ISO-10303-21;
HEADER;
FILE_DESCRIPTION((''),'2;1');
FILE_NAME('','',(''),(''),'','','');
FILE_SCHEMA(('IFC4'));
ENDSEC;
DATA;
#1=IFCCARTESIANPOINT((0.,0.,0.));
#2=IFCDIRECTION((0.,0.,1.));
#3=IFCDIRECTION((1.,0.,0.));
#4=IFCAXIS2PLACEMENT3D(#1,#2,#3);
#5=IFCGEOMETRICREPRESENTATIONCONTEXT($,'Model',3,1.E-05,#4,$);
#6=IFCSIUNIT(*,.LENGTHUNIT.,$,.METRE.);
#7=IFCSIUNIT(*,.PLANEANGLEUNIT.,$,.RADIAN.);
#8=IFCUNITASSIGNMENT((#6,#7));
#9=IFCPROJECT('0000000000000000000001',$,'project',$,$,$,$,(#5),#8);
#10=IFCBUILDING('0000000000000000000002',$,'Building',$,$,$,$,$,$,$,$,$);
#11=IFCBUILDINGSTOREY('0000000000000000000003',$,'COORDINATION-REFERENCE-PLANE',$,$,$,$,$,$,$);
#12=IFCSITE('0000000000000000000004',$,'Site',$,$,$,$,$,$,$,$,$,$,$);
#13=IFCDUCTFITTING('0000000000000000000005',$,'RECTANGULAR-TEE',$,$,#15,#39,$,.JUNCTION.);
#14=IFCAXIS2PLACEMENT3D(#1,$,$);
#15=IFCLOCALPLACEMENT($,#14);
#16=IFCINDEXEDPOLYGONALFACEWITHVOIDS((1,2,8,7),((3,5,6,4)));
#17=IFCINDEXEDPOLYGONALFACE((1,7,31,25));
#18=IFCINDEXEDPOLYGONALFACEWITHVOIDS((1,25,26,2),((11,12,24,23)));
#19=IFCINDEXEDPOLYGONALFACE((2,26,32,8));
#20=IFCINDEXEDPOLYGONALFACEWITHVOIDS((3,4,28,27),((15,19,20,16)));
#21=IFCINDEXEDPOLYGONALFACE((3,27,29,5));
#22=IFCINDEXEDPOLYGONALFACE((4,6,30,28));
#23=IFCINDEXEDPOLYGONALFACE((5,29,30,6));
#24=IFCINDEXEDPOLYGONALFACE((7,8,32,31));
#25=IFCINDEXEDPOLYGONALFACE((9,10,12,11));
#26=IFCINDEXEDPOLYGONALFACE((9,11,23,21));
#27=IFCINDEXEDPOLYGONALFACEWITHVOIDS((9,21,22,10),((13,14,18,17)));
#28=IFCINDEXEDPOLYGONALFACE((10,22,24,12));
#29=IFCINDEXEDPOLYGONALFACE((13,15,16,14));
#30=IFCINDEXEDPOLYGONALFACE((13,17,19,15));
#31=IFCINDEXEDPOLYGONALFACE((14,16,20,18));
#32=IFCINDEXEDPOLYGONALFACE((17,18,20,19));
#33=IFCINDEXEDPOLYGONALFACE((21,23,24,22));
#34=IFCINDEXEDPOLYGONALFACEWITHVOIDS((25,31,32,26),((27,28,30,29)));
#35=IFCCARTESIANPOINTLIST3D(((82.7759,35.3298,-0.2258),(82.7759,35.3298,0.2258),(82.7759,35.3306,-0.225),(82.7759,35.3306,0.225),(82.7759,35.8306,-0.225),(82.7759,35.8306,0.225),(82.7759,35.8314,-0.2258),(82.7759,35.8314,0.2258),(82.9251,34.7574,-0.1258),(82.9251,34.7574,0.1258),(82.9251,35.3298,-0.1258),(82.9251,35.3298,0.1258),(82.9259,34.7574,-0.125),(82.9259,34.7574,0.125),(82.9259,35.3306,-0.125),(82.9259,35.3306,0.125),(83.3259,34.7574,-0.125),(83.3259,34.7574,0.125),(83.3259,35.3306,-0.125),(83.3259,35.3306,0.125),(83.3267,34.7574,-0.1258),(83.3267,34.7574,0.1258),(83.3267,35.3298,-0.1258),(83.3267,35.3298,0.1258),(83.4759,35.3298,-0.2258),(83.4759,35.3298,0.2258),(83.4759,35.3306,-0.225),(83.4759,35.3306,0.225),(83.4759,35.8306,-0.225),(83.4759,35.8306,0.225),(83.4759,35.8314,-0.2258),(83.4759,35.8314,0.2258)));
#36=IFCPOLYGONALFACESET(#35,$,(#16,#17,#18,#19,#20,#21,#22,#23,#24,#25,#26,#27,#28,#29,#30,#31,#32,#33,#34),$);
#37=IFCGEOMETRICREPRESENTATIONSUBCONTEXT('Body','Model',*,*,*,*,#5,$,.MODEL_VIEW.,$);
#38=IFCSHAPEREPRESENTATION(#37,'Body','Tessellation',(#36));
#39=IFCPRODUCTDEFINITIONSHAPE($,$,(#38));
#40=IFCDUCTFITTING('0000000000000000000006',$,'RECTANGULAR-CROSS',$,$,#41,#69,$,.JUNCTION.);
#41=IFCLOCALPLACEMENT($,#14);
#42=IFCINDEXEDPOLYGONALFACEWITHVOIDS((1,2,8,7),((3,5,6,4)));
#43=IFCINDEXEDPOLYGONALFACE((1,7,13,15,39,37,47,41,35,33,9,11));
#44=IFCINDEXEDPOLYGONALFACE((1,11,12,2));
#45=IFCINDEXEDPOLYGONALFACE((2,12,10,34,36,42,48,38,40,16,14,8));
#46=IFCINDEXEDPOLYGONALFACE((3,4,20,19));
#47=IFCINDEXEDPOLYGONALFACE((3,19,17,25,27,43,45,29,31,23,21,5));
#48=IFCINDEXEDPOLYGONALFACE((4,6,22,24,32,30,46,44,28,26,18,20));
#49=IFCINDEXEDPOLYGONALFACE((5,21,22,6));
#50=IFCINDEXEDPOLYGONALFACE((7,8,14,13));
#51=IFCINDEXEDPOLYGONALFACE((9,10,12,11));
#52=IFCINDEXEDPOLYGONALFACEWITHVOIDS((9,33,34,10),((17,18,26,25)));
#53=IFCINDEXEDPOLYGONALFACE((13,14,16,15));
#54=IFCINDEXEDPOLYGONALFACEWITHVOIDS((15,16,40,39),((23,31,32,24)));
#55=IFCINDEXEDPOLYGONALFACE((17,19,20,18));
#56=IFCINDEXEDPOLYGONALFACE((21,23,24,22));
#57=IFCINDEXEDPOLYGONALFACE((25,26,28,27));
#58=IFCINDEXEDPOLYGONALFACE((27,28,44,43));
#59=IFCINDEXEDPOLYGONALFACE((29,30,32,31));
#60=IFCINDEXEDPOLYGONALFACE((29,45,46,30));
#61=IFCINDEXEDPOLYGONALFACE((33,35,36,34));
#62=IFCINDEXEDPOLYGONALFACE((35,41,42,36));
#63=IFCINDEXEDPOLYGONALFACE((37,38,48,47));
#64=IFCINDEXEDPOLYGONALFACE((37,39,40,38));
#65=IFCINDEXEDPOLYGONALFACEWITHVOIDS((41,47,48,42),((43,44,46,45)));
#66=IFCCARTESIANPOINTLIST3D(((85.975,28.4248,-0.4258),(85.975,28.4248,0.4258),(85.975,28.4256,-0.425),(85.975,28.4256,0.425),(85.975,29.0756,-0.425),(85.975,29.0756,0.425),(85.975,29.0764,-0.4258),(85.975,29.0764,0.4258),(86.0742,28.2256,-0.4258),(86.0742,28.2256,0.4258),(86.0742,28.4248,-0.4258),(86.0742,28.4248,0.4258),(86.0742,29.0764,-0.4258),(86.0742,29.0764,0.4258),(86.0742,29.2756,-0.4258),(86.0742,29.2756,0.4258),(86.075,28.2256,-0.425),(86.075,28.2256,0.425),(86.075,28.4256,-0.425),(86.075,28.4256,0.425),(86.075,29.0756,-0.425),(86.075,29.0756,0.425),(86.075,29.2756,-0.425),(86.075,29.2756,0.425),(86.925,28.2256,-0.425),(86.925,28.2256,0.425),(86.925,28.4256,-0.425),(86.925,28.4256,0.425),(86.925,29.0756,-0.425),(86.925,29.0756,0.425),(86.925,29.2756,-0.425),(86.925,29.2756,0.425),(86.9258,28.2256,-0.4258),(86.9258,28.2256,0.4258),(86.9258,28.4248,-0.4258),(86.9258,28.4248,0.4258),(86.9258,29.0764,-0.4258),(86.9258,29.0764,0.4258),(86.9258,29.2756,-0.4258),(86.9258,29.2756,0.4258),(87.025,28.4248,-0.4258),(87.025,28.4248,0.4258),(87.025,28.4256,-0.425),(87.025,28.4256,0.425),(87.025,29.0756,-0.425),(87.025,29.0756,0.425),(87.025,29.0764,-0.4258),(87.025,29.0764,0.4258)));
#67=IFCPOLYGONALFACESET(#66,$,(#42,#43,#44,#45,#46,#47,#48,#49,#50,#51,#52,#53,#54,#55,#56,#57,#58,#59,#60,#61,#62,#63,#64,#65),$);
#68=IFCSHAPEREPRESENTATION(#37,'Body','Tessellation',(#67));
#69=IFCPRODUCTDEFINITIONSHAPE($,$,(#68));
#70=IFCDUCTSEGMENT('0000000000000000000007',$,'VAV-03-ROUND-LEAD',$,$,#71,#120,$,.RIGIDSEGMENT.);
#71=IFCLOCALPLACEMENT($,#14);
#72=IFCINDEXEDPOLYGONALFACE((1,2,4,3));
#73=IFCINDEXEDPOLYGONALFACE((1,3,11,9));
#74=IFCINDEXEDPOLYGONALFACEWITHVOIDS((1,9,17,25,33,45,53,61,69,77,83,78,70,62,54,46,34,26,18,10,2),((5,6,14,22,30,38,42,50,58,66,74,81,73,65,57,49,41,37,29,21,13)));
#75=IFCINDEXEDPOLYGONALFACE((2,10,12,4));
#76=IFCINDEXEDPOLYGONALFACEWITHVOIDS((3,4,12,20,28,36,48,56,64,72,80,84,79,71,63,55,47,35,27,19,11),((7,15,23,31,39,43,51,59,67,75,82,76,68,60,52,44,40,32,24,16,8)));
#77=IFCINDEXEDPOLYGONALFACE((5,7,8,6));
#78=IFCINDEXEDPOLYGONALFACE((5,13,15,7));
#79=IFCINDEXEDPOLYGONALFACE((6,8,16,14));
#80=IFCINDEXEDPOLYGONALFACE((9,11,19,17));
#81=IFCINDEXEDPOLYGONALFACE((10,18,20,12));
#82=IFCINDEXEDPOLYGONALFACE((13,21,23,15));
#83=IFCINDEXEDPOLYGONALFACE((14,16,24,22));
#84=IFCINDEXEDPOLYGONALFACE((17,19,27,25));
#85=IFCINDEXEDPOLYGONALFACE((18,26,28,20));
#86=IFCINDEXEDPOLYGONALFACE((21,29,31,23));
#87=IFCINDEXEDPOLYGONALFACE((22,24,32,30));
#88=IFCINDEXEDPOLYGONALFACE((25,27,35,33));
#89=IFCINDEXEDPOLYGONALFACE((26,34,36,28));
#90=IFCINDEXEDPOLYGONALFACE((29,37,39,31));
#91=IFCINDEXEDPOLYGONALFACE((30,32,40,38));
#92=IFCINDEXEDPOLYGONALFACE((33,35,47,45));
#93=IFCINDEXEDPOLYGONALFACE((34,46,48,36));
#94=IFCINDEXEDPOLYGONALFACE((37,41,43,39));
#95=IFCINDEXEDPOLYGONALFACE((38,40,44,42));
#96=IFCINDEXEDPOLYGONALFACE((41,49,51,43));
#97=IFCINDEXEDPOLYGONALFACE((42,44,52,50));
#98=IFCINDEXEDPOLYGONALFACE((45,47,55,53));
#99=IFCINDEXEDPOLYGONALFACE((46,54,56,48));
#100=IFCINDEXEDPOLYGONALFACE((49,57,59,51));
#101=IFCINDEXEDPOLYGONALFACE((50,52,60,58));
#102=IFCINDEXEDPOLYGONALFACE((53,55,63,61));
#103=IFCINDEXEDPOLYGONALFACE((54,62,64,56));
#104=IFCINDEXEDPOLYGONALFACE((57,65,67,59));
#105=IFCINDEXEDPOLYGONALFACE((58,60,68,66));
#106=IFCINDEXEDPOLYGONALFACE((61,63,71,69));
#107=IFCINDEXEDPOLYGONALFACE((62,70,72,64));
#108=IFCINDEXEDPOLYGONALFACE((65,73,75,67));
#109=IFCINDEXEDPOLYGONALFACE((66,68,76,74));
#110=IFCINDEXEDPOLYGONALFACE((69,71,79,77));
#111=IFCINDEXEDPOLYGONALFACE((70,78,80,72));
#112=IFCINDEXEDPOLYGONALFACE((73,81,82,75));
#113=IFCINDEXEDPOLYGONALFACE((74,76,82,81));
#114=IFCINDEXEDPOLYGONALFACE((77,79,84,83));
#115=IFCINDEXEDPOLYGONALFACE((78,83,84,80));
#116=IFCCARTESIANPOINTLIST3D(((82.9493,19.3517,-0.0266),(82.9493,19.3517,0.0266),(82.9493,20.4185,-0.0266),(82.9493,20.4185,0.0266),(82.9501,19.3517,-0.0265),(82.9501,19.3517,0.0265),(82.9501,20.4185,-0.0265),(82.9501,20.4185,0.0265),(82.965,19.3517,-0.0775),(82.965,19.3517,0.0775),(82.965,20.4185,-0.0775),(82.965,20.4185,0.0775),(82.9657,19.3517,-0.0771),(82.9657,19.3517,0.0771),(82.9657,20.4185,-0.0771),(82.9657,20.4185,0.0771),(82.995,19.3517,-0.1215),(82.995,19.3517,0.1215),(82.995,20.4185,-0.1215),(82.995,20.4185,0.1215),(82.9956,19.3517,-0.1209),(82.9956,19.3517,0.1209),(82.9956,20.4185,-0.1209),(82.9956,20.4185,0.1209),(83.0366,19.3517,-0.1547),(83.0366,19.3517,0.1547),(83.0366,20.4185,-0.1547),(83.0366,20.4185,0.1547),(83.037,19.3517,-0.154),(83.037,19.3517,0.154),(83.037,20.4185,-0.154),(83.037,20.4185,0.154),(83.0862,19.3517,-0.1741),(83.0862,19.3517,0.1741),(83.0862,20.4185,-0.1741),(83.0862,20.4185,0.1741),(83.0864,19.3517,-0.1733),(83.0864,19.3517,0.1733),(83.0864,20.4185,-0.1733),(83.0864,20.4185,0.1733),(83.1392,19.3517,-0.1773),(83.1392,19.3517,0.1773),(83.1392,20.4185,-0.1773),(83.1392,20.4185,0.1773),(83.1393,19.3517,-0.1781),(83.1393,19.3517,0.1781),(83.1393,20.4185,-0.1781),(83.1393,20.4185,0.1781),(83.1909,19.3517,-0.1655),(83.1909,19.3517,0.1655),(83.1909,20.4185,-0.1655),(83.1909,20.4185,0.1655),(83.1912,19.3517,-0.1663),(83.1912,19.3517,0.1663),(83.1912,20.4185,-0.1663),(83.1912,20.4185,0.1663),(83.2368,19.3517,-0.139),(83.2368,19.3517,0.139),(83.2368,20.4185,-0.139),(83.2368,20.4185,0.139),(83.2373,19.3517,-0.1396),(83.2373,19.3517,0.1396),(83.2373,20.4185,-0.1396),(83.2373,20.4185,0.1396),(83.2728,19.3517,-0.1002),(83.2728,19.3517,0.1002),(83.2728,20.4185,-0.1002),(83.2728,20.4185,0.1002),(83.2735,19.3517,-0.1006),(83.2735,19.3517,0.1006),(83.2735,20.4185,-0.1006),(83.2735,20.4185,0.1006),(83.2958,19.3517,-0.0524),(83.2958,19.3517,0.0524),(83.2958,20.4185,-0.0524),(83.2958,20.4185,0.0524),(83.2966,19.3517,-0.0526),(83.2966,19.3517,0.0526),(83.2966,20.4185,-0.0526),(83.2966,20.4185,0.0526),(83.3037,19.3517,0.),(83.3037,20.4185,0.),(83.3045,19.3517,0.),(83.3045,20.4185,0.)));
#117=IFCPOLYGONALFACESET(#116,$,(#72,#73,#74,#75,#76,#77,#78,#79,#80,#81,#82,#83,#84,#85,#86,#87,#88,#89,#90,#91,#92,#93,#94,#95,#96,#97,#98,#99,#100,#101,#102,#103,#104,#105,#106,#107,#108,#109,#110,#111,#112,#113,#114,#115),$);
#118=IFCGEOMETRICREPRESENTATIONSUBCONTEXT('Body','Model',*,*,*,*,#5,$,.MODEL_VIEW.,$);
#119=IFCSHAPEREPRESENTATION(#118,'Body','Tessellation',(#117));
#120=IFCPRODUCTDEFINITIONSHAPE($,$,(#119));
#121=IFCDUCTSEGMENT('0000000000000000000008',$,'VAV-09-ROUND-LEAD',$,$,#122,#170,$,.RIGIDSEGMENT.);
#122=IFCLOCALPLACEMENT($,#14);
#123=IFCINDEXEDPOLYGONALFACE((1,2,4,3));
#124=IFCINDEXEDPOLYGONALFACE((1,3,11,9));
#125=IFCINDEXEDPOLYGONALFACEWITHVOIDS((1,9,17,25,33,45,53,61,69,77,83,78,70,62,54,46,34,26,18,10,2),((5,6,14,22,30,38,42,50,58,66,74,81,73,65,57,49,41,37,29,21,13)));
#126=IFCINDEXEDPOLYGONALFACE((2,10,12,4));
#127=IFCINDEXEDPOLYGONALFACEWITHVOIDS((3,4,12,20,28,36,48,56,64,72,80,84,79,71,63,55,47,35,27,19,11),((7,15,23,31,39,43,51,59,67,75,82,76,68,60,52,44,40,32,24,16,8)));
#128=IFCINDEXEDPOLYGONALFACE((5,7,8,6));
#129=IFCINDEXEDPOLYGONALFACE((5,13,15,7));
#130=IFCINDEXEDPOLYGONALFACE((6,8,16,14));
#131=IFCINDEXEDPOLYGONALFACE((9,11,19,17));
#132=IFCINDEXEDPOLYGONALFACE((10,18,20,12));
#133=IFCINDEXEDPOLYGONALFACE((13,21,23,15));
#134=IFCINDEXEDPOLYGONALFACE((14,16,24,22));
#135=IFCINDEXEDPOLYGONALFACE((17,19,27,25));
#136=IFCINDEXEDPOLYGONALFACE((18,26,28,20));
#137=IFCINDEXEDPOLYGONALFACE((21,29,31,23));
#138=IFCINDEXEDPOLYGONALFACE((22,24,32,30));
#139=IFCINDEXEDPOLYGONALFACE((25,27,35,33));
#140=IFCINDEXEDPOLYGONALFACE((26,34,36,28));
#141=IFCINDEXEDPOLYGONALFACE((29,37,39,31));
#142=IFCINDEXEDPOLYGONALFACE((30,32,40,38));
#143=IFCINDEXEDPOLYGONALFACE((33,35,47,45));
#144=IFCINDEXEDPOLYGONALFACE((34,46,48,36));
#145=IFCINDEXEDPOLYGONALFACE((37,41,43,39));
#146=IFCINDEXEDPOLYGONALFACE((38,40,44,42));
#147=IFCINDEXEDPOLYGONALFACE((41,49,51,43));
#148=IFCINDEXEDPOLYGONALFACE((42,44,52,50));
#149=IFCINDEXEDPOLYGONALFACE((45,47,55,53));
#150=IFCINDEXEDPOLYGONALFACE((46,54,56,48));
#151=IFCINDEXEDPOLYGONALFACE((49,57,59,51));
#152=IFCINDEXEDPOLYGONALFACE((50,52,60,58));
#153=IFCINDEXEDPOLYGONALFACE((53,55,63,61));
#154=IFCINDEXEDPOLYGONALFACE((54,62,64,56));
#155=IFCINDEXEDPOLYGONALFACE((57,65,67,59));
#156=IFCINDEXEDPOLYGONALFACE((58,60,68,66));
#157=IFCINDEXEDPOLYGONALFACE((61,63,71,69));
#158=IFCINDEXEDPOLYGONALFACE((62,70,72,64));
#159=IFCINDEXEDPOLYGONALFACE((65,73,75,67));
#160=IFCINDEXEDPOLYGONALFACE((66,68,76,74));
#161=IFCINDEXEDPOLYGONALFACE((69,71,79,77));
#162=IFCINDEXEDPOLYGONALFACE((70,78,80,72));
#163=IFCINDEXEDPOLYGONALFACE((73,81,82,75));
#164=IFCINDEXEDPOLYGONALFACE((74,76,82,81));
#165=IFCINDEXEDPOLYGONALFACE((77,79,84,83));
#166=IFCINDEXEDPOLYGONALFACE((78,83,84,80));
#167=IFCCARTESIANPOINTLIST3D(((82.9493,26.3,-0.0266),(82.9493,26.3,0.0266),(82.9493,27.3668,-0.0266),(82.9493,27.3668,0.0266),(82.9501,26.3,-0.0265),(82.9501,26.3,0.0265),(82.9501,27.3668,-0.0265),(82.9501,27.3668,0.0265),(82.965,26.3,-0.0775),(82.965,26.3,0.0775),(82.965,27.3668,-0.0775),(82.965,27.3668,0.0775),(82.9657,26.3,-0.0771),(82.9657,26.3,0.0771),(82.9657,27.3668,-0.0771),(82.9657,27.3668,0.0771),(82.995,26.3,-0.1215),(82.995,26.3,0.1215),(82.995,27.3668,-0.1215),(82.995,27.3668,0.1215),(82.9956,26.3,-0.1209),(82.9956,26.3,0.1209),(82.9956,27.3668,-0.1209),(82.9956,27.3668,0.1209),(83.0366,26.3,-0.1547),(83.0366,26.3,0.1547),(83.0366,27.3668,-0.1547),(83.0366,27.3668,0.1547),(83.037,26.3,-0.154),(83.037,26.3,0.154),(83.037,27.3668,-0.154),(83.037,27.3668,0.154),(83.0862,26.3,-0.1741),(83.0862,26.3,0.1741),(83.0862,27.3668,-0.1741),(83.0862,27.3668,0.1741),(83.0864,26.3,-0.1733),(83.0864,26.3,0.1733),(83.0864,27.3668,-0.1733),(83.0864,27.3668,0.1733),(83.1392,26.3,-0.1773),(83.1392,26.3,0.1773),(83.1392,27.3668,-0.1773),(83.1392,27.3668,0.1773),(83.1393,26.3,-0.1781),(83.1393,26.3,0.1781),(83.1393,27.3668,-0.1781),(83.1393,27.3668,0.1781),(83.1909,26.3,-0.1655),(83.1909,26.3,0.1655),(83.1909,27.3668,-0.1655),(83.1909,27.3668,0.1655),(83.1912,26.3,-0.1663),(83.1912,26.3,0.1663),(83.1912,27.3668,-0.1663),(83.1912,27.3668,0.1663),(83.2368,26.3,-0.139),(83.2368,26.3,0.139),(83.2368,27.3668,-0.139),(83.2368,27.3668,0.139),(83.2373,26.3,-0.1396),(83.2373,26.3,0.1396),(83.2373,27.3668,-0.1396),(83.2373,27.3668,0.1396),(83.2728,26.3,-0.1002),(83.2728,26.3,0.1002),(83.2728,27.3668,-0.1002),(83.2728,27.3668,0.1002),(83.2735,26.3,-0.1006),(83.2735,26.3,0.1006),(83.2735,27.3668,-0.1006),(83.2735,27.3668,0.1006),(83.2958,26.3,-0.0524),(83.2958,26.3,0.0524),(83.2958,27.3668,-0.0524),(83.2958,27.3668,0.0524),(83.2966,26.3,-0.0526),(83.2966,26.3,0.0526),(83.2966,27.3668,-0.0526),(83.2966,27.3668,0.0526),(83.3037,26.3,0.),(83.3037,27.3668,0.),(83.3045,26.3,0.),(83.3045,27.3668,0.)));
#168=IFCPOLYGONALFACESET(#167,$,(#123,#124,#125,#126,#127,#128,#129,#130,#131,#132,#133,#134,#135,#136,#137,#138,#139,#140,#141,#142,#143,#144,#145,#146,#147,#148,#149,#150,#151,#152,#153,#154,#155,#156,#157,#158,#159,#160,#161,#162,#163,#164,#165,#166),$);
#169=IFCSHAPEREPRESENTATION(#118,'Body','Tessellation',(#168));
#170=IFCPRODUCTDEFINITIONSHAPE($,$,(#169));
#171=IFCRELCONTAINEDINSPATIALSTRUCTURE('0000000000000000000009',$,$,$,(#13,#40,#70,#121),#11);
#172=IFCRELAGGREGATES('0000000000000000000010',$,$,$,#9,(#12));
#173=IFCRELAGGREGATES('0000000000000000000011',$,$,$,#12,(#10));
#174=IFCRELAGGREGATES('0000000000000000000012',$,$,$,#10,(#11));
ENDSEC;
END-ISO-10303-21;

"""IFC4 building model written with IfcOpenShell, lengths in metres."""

from ifc_helpers import new_model, si_unit, frame, origin, origin_with_axes, place, context, subcontext, project, spatial, rectangle, hollow_circle, extrude, boolean, element, save


model = new_model("IFC4")

# Units and contexts
model_context = context("Model", 3, precision=1e-05, world=origin_with_axes())
body_context_1 = subcontext(model_context, "Body", "Model", "MODEL_VIEW")
body_context_2 = subcontext(model_context, "Body", "Model", "MODEL_VIEW")
ifc_project = project(units=[si_unit("LENGTHUNIT", "METRE"), si_unit("PLANEANGLEUNIT", "RADIAN")], contexts=[model_context])

# Site, building, storey
site = spatial("IfcSite", under=ifc_project, Name="Site")
building = spatial("IfcBuilding", under=site, Name="Building")
storey = spatial("IfcBuildingStorey", under=building, Name="COORDINATION-REFERENCE-PLANE")

# Duct fittings
duct_fitting_1_placement = place(None, frame((83.1259, 35.5806, 0.0), z_axis=(-1.0, 0.0, 0.0), x_axis=(0.0, -1.0, 0.0)))
solid_1 = boolean("UNION", extrude(rectangle(XDim=0.5, YDim=0.45), frame((0.0, 0.0, -0.35), z_axis=(0.0, 0.0, 1.0), x_axis=(1.0, 0.0, 0.0)), (0.0, 0.0, 1.0), 0.7), extrude(rectangle(XDim=0.4, YDim=0.25), frame((0.0, 0.0, 0.0), z_axis=(1.0, 0.0, 0.0), x_axis=(0.0, 0.0, -1.0)), (0.0, 0.0, 1.0), 0.8232))
element("IfcDuctFitting", 1, at=duct_fitting_1_placement, inside=storey, Name="RECTANGULAR-TEE", PredefinedType="JUNCTION", context=body_context_1, shape_type="CSG", body=[
    boolean("DIFFERENCE", boolean("UNION", extrude(rectangle(XDim=0.5016, YDim=0.4516), frame((0.0, 0.0, -0.35), z_axis=(0.0, 0.0, 1.0), x_axis=(1.0, 0.0, 0.0)), (0.0, 0.0, 1.0), 0.7), extrude(rectangle(XDim=0.4016, YDim=0.2516), frame((0.0, 0.0, 0.0), z_axis=(1.0, 0.0, 0.0), x_axis=(0.0, 0.0, -1.0)), (0.0, 0.0, 1.0), 0.8232)), solid_1),
])
duct_fitting_2_placement = place(None, frame((86.5, 28.7506, 0.0), z_axis=(0.0, -1.0, 0.0), x_axis=(1.0, 0.0, 0.0)))
solid_2 = boolean("UNION", extrude(rectangle(XDim=0.85, YDim=0.85), frame((0.0, 0.0, -0.525), z_axis=(0.0, 0.0, 1.0), x_axis=(1.0, 0.0, 0.0)), (0.0, 0.0, 1.0), 1.05), extrude(rectangle(XDim=0.65, YDim=0.85), frame((-0.525, 0.0, 0.0), z_axis=(1.0, 0.0, 0.0), x_axis=(0.0, 0.0, -1.0)), (0.0, 0.0, 1.0), 1.05))
element("IfcDuctFitting", 2, at=duct_fitting_2_placement, inside=storey, Name="RECTANGULAR-CROSS", PredefinedType="JUNCTION", context=body_context_1, shape_type="CSG", body=[
    boolean("DIFFERENCE", boolean("UNION", extrude(rectangle(XDim=0.8516, YDim=0.8516), frame((0.0, 0.0, -0.525), z_axis=(0.0, 0.0, 1.0), x_axis=(1.0, 0.0, 0.0)), (0.0, 0.0, 1.0), 1.05), extrude(rectangle(XDim=0.6516, YDim=0.8516), frame((-0.525, 0.0, 0.0), z_axis=(1.0, 0.0, 0.0), x_axis=(0.0, 0.0, -1.0)), (0.0, 0.0, 1.0), 1.05)), solid_2),
])

# Duct segments
for number, where, z_axis, x_axis, name in (
    (3, (83.1259, 20.4185, 0.0), (0.0, -1.0, 0.0), (1.0, 0.0, 0.0), "VAV-03-ROUND-LEAD"),
    (4, (83.1259, 27.3668, 0.0), (0.0, -1.0, 0.0), (1.0, 0.0, 0.0), "VAV-09-ROUND-LEAD"),
):
    element("IfcDuctSegment", number, at=place(None, frame(where, z_axis=z_axis, x_axis=x_axis)), inside=storey, Name=name, PredefinedType="RIGIDSEGMENT", context=body_context_2, shape_type="SweptSolid", body=[
        extrude(hollow_circle(Radius=0.1786, WallThickness=0.0008), origin(), (0.0, 0.0, 1.0), 1.0668),
    ])

save(model, "model.ifc")
